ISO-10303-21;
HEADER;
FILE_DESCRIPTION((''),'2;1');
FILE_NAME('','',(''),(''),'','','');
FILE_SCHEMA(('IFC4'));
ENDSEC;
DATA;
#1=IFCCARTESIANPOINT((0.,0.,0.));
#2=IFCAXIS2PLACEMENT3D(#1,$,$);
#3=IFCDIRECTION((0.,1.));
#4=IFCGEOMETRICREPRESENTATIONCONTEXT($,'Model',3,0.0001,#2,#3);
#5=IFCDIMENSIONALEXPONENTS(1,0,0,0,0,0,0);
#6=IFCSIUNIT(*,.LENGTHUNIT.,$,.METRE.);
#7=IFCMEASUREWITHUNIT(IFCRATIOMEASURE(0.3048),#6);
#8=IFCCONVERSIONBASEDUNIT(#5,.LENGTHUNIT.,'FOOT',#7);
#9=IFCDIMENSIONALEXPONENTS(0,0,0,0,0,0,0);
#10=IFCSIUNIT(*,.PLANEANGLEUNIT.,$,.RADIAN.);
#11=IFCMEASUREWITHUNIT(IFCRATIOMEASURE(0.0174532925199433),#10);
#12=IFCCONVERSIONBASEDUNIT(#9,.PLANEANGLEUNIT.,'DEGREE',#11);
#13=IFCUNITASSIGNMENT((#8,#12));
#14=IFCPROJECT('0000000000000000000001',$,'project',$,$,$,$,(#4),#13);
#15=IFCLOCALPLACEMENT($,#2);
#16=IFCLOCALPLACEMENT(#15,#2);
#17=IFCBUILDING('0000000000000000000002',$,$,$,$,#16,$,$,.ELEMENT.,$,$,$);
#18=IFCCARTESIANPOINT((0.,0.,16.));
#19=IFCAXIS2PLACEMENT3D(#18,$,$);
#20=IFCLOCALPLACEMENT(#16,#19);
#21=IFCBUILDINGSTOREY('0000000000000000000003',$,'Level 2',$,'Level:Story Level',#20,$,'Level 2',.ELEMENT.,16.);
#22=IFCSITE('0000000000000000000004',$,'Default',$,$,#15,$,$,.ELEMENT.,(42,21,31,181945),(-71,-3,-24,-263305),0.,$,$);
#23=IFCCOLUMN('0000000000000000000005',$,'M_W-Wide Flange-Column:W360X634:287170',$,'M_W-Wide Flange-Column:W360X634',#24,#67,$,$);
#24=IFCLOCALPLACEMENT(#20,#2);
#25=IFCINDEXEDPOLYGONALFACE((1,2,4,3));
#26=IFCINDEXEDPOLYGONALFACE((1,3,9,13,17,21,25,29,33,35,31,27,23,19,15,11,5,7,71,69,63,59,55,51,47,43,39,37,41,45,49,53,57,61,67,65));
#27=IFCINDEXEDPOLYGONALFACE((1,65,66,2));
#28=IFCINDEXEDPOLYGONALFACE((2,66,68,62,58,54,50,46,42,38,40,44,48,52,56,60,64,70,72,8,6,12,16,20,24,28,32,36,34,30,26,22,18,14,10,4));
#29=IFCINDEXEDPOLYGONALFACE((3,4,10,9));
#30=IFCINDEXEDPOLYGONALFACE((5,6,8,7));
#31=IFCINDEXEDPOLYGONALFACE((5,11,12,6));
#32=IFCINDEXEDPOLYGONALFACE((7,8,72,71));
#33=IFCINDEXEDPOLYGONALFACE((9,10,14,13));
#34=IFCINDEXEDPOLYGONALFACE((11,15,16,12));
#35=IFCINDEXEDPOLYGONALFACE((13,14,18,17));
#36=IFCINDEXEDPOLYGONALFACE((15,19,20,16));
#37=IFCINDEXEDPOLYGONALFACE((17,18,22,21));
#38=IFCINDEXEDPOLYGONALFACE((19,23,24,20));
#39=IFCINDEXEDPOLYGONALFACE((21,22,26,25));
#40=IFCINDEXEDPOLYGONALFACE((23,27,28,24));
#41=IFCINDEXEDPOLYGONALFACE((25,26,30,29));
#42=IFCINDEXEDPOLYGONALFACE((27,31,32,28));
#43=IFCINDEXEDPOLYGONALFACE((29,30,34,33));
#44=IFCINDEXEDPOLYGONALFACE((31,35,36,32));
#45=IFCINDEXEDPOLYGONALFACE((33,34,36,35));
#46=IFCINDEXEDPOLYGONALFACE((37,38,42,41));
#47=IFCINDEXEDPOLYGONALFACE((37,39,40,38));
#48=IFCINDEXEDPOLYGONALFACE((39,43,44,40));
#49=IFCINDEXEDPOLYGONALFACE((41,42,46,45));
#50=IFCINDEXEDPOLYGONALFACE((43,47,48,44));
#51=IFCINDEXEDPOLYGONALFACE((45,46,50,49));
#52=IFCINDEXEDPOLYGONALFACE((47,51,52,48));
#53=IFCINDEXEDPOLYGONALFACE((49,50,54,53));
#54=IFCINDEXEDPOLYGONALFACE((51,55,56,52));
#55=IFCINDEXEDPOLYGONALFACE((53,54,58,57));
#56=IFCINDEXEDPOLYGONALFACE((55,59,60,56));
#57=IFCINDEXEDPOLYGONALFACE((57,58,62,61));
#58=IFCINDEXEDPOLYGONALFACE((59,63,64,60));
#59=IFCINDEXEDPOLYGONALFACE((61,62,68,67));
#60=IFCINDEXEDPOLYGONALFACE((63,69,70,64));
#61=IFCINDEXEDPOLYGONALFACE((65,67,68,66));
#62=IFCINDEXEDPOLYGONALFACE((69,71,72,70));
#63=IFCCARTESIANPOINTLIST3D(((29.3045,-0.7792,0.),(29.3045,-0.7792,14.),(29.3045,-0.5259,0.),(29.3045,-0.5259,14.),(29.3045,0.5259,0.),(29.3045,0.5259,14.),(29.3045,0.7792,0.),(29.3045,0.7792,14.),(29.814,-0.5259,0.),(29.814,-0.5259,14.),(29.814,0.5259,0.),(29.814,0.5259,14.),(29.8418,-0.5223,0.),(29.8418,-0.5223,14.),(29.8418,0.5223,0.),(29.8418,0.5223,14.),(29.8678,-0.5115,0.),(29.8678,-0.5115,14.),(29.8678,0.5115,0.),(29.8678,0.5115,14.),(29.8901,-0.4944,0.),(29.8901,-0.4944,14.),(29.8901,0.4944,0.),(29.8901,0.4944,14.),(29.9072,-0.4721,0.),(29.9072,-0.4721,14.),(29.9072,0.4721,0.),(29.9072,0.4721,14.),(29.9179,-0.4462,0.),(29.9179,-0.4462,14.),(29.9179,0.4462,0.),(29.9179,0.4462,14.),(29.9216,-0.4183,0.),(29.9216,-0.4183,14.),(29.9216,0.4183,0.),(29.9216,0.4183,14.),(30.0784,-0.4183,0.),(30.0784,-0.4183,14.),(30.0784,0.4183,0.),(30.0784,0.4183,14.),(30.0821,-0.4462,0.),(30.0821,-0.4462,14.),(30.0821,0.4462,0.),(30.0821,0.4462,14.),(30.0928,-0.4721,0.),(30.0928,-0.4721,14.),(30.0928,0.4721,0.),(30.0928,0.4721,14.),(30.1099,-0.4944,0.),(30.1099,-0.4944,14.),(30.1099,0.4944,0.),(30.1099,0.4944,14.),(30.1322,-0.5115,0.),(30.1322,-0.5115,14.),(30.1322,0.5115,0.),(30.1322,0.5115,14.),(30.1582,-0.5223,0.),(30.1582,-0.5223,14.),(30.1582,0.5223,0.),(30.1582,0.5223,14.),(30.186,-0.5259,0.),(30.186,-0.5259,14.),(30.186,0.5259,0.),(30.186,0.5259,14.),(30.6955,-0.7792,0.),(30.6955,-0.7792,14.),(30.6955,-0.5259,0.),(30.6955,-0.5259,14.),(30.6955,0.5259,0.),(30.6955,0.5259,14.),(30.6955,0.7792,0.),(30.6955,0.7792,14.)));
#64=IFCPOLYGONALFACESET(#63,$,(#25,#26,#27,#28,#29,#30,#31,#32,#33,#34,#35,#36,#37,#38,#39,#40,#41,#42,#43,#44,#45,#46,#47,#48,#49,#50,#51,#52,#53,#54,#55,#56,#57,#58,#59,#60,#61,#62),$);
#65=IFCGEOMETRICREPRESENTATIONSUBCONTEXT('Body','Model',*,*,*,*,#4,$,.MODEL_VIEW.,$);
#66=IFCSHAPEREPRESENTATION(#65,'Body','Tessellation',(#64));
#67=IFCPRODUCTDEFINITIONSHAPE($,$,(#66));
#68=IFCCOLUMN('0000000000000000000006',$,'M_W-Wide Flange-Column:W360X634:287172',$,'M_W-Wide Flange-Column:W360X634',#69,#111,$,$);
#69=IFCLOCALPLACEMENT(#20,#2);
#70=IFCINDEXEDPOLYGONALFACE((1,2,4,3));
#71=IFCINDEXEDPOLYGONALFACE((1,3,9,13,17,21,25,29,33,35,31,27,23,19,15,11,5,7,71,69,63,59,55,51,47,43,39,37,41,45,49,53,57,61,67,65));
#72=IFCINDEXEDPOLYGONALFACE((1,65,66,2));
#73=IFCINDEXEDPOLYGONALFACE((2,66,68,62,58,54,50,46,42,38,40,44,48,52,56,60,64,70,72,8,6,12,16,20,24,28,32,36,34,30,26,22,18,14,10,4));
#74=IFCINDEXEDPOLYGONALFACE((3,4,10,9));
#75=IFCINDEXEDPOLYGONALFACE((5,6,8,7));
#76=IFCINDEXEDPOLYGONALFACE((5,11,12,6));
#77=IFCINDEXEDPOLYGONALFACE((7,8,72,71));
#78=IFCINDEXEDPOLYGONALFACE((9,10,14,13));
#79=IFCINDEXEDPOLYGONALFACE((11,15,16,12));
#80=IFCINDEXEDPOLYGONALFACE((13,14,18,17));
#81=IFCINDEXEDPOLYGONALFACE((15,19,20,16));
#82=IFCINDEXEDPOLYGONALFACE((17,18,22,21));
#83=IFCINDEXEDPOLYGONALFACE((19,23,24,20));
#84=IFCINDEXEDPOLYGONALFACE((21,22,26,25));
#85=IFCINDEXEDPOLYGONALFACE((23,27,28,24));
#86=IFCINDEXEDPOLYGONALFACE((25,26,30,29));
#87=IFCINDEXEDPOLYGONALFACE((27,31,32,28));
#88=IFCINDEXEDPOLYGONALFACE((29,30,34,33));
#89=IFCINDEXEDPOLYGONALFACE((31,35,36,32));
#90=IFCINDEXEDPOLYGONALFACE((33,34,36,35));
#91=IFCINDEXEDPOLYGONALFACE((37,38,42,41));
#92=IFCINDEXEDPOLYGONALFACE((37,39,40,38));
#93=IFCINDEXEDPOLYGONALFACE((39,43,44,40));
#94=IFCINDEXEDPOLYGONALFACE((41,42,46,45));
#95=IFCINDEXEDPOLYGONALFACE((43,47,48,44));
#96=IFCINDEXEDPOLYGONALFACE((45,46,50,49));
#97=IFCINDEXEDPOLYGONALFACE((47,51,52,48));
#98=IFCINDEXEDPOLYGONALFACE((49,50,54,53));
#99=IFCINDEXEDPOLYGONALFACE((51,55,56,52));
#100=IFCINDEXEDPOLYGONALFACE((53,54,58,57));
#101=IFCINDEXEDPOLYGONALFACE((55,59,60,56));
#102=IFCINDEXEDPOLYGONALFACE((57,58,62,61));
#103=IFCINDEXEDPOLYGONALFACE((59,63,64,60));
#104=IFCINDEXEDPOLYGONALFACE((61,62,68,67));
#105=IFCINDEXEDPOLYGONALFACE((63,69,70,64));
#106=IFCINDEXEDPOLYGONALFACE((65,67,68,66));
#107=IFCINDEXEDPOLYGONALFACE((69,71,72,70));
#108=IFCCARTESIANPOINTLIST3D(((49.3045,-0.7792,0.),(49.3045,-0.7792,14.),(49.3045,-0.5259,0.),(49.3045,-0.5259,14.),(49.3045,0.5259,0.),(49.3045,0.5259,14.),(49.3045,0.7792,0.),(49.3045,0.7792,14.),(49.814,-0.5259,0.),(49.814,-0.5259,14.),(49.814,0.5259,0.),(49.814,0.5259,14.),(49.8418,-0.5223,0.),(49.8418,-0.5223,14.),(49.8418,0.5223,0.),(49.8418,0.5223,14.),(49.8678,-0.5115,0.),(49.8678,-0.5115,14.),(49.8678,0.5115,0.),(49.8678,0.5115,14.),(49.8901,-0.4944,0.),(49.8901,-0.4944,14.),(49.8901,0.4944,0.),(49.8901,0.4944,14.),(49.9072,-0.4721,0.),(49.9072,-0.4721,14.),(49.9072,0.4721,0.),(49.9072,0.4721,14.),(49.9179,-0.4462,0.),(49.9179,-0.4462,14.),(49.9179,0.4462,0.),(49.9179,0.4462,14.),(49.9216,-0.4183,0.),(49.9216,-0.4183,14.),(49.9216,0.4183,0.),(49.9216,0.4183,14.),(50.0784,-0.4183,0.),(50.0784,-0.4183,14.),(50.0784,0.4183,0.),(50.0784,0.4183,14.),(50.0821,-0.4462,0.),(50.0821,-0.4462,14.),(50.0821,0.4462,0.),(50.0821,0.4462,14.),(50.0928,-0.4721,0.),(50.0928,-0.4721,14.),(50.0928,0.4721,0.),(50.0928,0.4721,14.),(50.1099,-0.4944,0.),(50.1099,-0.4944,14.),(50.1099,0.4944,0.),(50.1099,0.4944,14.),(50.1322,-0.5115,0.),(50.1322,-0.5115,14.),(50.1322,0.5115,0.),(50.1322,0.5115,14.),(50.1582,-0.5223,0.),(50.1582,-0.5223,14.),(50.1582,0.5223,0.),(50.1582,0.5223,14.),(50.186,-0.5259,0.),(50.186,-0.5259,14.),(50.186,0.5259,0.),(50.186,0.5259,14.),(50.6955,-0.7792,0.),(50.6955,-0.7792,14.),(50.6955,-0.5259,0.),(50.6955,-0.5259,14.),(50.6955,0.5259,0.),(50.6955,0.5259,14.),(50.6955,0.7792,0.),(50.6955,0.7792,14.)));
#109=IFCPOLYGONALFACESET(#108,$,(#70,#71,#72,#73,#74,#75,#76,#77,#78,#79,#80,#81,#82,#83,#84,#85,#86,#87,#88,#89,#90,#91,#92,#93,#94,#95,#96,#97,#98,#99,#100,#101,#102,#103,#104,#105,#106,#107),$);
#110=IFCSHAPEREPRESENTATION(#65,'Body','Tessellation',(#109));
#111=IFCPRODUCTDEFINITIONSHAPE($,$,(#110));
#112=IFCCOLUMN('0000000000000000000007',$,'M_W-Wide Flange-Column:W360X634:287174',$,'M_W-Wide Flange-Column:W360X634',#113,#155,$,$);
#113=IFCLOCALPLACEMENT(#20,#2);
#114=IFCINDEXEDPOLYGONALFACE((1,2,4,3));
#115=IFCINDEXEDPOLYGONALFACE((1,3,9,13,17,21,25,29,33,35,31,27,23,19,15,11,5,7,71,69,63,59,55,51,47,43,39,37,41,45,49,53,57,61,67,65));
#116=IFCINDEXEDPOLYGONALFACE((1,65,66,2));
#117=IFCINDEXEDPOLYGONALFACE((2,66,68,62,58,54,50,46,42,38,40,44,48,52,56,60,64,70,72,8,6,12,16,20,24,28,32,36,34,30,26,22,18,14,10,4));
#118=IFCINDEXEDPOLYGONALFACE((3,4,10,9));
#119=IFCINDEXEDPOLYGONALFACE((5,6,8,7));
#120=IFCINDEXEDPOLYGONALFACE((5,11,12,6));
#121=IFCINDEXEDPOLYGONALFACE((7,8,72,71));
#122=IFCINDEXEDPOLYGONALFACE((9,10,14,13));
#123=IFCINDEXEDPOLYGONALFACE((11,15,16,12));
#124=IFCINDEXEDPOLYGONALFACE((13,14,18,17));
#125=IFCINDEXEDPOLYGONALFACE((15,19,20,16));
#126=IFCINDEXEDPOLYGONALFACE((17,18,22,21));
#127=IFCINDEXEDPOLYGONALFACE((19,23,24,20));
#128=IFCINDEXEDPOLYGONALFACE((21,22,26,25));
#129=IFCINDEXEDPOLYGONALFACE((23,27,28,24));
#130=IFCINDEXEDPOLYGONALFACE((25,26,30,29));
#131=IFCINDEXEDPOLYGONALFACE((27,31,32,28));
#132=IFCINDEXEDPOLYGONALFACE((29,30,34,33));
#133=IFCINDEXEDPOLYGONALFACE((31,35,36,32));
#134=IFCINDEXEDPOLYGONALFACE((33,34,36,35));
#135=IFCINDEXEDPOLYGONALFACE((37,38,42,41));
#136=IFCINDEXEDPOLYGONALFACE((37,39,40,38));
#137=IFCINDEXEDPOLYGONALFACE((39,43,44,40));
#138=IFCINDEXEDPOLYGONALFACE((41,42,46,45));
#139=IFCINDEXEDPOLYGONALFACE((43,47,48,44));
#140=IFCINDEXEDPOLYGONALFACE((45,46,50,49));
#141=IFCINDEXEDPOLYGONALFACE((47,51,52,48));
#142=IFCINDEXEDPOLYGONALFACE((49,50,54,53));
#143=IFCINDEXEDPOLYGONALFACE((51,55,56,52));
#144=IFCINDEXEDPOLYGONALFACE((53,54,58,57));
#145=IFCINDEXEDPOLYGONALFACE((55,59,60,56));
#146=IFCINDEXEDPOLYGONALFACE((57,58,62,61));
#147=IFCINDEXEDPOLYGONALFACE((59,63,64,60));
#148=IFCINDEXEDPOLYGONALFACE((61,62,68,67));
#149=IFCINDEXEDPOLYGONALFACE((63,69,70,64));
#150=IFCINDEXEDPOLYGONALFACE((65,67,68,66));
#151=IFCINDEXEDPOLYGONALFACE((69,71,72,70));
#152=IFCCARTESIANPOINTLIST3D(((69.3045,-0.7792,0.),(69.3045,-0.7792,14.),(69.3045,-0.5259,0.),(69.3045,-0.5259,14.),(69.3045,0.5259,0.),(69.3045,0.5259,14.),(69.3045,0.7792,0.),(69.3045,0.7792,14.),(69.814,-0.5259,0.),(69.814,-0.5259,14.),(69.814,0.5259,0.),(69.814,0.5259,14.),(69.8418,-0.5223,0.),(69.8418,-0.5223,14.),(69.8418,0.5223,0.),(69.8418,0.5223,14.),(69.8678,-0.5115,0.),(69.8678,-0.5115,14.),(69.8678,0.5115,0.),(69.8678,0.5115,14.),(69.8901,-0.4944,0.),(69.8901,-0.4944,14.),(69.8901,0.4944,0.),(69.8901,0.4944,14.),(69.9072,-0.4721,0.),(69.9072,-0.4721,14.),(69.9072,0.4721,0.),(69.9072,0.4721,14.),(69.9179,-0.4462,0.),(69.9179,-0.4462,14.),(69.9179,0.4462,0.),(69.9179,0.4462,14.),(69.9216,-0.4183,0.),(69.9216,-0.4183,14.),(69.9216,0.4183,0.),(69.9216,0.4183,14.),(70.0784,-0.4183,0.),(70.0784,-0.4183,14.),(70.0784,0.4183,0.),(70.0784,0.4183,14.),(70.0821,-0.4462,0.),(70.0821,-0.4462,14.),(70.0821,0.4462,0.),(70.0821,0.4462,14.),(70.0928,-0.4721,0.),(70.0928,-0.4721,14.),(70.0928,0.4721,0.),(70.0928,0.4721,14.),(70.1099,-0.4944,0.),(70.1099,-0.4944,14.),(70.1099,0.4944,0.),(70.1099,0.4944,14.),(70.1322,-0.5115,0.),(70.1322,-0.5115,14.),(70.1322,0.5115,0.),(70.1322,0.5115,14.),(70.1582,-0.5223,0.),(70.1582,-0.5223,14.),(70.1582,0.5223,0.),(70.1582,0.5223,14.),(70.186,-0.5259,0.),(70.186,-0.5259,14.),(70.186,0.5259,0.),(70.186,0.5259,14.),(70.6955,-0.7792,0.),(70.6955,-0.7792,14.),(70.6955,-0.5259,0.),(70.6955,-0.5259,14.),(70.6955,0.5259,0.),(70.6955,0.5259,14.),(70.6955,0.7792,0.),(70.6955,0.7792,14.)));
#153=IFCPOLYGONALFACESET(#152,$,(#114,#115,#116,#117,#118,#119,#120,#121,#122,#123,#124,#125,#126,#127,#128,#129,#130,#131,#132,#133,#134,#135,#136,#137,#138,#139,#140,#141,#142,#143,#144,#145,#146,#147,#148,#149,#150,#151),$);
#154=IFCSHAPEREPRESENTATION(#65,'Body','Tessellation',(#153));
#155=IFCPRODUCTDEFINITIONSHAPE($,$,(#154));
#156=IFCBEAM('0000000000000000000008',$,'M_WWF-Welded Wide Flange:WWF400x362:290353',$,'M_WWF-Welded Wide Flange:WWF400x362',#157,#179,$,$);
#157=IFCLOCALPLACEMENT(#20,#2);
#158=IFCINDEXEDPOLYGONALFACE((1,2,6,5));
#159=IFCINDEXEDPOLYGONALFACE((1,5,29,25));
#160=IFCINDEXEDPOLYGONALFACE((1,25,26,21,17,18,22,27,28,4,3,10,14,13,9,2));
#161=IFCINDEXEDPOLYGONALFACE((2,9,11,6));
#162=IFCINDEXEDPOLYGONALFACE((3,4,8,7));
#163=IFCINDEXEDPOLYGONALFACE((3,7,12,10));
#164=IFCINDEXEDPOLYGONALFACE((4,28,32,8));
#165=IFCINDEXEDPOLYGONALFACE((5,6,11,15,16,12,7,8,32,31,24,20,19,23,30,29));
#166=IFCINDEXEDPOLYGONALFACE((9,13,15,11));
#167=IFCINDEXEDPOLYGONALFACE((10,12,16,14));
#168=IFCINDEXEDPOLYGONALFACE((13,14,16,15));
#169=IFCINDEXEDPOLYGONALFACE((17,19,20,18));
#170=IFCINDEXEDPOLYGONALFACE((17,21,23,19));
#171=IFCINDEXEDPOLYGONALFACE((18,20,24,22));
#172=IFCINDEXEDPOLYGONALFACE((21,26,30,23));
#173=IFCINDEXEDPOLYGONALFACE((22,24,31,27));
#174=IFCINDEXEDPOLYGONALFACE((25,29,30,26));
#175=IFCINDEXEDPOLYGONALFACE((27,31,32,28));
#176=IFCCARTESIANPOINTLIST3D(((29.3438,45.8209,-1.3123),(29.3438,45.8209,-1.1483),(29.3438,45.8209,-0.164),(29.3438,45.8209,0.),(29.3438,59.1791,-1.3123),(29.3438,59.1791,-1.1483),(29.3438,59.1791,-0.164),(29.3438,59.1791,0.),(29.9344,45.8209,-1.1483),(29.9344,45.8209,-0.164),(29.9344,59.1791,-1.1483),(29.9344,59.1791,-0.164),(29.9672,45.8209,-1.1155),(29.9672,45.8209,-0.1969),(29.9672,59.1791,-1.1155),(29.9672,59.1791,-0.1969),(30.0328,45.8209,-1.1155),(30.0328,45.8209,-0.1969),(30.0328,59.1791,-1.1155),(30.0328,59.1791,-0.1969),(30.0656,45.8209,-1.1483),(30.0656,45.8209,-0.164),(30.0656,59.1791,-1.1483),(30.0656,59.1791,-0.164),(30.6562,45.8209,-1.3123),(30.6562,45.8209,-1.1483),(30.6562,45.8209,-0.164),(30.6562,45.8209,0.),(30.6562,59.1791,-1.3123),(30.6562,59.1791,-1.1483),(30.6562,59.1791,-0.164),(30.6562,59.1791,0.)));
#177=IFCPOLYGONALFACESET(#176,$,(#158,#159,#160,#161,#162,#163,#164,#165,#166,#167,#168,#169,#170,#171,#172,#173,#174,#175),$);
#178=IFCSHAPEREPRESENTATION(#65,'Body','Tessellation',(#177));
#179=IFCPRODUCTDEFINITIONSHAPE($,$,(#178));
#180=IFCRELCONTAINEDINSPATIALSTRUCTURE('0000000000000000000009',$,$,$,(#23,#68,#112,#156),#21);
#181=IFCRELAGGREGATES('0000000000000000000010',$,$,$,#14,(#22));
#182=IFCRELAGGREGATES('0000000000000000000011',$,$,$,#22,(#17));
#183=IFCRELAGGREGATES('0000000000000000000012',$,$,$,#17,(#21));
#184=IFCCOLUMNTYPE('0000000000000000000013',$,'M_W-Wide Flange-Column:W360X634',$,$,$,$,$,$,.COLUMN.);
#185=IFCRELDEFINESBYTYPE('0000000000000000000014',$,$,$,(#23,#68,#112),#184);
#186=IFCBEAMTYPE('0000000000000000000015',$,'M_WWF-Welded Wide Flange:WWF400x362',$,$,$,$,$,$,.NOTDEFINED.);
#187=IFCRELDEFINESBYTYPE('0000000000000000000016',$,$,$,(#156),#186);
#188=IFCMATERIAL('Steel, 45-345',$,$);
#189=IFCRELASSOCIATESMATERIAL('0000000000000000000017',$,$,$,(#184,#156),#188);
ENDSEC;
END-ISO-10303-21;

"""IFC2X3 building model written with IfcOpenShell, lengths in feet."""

from ifc_helpers import new_model, entity, si_unit, converted_unit, direction, frame, frame_2d, origin, place, context, subcontext, project, spatial, polyline, circle_curve, parameter, trimmed, segment, composite_curve, outline, extrude, source, transform, mapped, material, type_object, type_shapes, element, save


model = new_model("IFC2X3")

# Units and contexts
model_context = context("Model", 3, precision=0.0001, world=origin(), true_north=direction((0.0, 1.0)))
body_context = subcontext(model_context, "Body", "Model", "MODEL_VIEW")
ifc_project = project(units=[converted_unit("LENGTHUNIT", "FOOT", entity("IfcRatioMeasure", 0.3048), si_unit("LENGTHUNIT", "METRE"), dimensions=[1, 0, 0, 0, 0, 0, 0]), converted_unit("PLANEANGLEUNIT", "DEGREE", entity("IfcRatioMeasure", 0.0174532925199433), si_unit("PLANEANGLEUNIT", "RADIAN"), dimensions=[0, 0, 0, 0, 0, 0, 0])], contexts=[model_context])

# Site, building, storey
site_placement = place(None, origin())
site = spatial("IfcSite", under=ifc_project, at=site_placement, Name="Default", CompositionType="ELEMENT", RefLatitude=(42, 21, 31, 181945), RefLongitude=(-71, -3, -24, -263305), RefElevation=0.0)
building_placement = place(site_placement, origin())
building = spatial("IfcBuilding", under=site, at=building_placement, CompositionType="ELEMENT")
storey_placement = place(building_placement, frame((0.0, 0.0, 16.0)))
storey = spatial("IfcBuildingStorey", under=building, at=storey_placement, Name="Level 2", ObjectType="Level:Story Level", LongName="Level 2", CompositionType="ELEMENT", Elevation=16.0)

# Columns
ifc_material = material(Name="Steel, 45-345")
column_type = type_object("IfcColumnType", Name="M_W-Wide Flange-Column:W360X634", PredefinedType="COLUMN", material=ifc_material)
shared_shape = source(origin(), body_context, "Body", "SweptSolid", [
    extrude(outline(composite_curve([segment(polyline([(0.5259, -0.6955), (0.7792, -0.6955)]), True, "CONTINUOUS"), segment(polyline([(0.7792, -0.6955), (0.7792, 0.6955)]), True, "CONTINUOUS"), segment(polyline([(0.7792, 0.6955), (0.5259, 0.6955)]), True, "CONTINUOUS"), segment(polyline([(0.5259, 0.6955), (0.5259, 0.186)]), True, "CONTINUOUS"), segment(trimmed(circle_curve(frame_2d((0.4183, 0.186), x_axis=(1.0, 0.0)), 0.1076), [parameter(270.0)], [parameter(0.0)], True, "PARAMETER"), False, "CONTINUOUS"), segment(polyline([(0.4183, 0.0784), (-0.4183, 0.0784)]), True, "CONTINUOUS"), segment(trimmed(circle_curve(frame_2d((-0.4183, 0.186), x_axis=(0.0, -1.0)), 0.1076), [parameter(270.0)], [parameter(0.0)], True, "PARAMETER"), False, "CONTINUOUS"), segment(polyline([(-0.5259, 0.186), (-0.5259, 0.6955)]), True, "CONTINUOUS"), segment(polyline([(-0.5259, 0.6955), (-0.7792, 0.6955)]), True, "CONTINUOUS"), segment(polyline([(-0.7792, 0.6955), (-0.7792, -0.6955)]), True, "CONTINUOUS"), segment(polyline([(-0.7792, -0.6955), (-0.5259, -0.6955)]), True, "CONTINUOUS"), segment(polyline([(-0.5259, -0.6955), (-0.5259, -0.186)]), True, "CONTINUOUS"), segment(trimmed(circle_curve(frame_2d((-0.4183, -0.186), x_axis=(-1.0, 0.0)), 0.1076), [parameter(270.0)], [parameter(0.0)], True, "PARAMETER"), False, "CONTINUOUS"), segment(polyline([(-0.4183, -0.0784), (0.4183, -0.0784)]), True, "CONTINUOUS"), segment(trimmed(circle_curve(frame_2d((0.4183, -0.186), x_axis=(0.0, 1.0)), 0.1076), [parameter(270.0)], [parameter(0.0)], True, "PARAMETER"), False, "CONTINUOUS"), segment(polyline([(0.5259, -0.186), (0.5259, -0.6955)]), True, "CONTINUOUS")], self_intersect=False)), frame((0.0, 0.0, 16.0), z_axis=(0.0, 0.0, 1.0), x_axis=(0.0, -1.0, 0.0)), (0.0, 0.0, 1.0), 14.0),
])
type_shapes(column_type, [shared_shape])
for number, where, name in (
    (1, (30.0, 0.0, -16.0), "M_W-Wide Flange-Column:W360X634:287170"),
    (2, (50.0, 0.0, -16.0), "M_W-Wide Flange-Column:W360X634:287172"),
    (3, (70.0, 0.0, -16.0), "M_W-Wide Flange-Column:W360X634:287174"),
):
    element("IfcColumn", number, at=place(storey_placement, frame(where)), inside=storey, type_object=column_type, Name=name, ObjectType="M_W-Wide Flange-Column:W360X634", context=body_context, shape_type="MappedRepresentation", body=[
        mapped(shared_shape, transform((0.0, 0.0, 0.0), scale=1.0)),
    ])

# Beam
beam_type = type_object("IfcBeamType", Name="M_WWF-Welded Wide Flange:WWF400x362", PredefinedType="NOTDEFINED")
beam_1_placement = place(storey_placement, frame((30.0, 45.0, 0.0), z_axis=(0.0, 0.0, 1.0), x_axis=(0.0, 1.0, 0.0)))
element("IfcBeam", 4, at=beam_1_placement, inside=storey, type_object=beam_type, material=ifc_material, Name="M_WWF-Welded Wide Flange:WWF400x362:290353", ObjectType="M_WWF-Welded Wide Flange:WWF400x362", context=body_context, shape_type="SweptSolid", body=[
    extrude(outline(polyline([(-0.6562, -0.6562), (-0.4921, -0.6562), (-0.4921, -0.0656), (-0.4593, -0.0328), (0.4593, -0.0328), (0.4921, -0.0656), (0.4921, -0.6562), (0.6562, -0.6562), (0.6562, 0.6562), (0.4921, 0.6562), (0.4921, 0.0656), (0.4593, 0.0328), (-0.4593, 0.0328), (-0.4921, 0.0656), (-0.4921, 0.6562), (-0.6562, 0.6562), (-0.6562, -0.6562)])), frame((0.8209, 0.0, -0.6562), z_axis=(1.0, 0.0, 0.0), x_axis=(0.0, 0.0, -1.0)), (0.0, 0.0, 1.0), 13.3583),
])

save(model, "model.ifc")
